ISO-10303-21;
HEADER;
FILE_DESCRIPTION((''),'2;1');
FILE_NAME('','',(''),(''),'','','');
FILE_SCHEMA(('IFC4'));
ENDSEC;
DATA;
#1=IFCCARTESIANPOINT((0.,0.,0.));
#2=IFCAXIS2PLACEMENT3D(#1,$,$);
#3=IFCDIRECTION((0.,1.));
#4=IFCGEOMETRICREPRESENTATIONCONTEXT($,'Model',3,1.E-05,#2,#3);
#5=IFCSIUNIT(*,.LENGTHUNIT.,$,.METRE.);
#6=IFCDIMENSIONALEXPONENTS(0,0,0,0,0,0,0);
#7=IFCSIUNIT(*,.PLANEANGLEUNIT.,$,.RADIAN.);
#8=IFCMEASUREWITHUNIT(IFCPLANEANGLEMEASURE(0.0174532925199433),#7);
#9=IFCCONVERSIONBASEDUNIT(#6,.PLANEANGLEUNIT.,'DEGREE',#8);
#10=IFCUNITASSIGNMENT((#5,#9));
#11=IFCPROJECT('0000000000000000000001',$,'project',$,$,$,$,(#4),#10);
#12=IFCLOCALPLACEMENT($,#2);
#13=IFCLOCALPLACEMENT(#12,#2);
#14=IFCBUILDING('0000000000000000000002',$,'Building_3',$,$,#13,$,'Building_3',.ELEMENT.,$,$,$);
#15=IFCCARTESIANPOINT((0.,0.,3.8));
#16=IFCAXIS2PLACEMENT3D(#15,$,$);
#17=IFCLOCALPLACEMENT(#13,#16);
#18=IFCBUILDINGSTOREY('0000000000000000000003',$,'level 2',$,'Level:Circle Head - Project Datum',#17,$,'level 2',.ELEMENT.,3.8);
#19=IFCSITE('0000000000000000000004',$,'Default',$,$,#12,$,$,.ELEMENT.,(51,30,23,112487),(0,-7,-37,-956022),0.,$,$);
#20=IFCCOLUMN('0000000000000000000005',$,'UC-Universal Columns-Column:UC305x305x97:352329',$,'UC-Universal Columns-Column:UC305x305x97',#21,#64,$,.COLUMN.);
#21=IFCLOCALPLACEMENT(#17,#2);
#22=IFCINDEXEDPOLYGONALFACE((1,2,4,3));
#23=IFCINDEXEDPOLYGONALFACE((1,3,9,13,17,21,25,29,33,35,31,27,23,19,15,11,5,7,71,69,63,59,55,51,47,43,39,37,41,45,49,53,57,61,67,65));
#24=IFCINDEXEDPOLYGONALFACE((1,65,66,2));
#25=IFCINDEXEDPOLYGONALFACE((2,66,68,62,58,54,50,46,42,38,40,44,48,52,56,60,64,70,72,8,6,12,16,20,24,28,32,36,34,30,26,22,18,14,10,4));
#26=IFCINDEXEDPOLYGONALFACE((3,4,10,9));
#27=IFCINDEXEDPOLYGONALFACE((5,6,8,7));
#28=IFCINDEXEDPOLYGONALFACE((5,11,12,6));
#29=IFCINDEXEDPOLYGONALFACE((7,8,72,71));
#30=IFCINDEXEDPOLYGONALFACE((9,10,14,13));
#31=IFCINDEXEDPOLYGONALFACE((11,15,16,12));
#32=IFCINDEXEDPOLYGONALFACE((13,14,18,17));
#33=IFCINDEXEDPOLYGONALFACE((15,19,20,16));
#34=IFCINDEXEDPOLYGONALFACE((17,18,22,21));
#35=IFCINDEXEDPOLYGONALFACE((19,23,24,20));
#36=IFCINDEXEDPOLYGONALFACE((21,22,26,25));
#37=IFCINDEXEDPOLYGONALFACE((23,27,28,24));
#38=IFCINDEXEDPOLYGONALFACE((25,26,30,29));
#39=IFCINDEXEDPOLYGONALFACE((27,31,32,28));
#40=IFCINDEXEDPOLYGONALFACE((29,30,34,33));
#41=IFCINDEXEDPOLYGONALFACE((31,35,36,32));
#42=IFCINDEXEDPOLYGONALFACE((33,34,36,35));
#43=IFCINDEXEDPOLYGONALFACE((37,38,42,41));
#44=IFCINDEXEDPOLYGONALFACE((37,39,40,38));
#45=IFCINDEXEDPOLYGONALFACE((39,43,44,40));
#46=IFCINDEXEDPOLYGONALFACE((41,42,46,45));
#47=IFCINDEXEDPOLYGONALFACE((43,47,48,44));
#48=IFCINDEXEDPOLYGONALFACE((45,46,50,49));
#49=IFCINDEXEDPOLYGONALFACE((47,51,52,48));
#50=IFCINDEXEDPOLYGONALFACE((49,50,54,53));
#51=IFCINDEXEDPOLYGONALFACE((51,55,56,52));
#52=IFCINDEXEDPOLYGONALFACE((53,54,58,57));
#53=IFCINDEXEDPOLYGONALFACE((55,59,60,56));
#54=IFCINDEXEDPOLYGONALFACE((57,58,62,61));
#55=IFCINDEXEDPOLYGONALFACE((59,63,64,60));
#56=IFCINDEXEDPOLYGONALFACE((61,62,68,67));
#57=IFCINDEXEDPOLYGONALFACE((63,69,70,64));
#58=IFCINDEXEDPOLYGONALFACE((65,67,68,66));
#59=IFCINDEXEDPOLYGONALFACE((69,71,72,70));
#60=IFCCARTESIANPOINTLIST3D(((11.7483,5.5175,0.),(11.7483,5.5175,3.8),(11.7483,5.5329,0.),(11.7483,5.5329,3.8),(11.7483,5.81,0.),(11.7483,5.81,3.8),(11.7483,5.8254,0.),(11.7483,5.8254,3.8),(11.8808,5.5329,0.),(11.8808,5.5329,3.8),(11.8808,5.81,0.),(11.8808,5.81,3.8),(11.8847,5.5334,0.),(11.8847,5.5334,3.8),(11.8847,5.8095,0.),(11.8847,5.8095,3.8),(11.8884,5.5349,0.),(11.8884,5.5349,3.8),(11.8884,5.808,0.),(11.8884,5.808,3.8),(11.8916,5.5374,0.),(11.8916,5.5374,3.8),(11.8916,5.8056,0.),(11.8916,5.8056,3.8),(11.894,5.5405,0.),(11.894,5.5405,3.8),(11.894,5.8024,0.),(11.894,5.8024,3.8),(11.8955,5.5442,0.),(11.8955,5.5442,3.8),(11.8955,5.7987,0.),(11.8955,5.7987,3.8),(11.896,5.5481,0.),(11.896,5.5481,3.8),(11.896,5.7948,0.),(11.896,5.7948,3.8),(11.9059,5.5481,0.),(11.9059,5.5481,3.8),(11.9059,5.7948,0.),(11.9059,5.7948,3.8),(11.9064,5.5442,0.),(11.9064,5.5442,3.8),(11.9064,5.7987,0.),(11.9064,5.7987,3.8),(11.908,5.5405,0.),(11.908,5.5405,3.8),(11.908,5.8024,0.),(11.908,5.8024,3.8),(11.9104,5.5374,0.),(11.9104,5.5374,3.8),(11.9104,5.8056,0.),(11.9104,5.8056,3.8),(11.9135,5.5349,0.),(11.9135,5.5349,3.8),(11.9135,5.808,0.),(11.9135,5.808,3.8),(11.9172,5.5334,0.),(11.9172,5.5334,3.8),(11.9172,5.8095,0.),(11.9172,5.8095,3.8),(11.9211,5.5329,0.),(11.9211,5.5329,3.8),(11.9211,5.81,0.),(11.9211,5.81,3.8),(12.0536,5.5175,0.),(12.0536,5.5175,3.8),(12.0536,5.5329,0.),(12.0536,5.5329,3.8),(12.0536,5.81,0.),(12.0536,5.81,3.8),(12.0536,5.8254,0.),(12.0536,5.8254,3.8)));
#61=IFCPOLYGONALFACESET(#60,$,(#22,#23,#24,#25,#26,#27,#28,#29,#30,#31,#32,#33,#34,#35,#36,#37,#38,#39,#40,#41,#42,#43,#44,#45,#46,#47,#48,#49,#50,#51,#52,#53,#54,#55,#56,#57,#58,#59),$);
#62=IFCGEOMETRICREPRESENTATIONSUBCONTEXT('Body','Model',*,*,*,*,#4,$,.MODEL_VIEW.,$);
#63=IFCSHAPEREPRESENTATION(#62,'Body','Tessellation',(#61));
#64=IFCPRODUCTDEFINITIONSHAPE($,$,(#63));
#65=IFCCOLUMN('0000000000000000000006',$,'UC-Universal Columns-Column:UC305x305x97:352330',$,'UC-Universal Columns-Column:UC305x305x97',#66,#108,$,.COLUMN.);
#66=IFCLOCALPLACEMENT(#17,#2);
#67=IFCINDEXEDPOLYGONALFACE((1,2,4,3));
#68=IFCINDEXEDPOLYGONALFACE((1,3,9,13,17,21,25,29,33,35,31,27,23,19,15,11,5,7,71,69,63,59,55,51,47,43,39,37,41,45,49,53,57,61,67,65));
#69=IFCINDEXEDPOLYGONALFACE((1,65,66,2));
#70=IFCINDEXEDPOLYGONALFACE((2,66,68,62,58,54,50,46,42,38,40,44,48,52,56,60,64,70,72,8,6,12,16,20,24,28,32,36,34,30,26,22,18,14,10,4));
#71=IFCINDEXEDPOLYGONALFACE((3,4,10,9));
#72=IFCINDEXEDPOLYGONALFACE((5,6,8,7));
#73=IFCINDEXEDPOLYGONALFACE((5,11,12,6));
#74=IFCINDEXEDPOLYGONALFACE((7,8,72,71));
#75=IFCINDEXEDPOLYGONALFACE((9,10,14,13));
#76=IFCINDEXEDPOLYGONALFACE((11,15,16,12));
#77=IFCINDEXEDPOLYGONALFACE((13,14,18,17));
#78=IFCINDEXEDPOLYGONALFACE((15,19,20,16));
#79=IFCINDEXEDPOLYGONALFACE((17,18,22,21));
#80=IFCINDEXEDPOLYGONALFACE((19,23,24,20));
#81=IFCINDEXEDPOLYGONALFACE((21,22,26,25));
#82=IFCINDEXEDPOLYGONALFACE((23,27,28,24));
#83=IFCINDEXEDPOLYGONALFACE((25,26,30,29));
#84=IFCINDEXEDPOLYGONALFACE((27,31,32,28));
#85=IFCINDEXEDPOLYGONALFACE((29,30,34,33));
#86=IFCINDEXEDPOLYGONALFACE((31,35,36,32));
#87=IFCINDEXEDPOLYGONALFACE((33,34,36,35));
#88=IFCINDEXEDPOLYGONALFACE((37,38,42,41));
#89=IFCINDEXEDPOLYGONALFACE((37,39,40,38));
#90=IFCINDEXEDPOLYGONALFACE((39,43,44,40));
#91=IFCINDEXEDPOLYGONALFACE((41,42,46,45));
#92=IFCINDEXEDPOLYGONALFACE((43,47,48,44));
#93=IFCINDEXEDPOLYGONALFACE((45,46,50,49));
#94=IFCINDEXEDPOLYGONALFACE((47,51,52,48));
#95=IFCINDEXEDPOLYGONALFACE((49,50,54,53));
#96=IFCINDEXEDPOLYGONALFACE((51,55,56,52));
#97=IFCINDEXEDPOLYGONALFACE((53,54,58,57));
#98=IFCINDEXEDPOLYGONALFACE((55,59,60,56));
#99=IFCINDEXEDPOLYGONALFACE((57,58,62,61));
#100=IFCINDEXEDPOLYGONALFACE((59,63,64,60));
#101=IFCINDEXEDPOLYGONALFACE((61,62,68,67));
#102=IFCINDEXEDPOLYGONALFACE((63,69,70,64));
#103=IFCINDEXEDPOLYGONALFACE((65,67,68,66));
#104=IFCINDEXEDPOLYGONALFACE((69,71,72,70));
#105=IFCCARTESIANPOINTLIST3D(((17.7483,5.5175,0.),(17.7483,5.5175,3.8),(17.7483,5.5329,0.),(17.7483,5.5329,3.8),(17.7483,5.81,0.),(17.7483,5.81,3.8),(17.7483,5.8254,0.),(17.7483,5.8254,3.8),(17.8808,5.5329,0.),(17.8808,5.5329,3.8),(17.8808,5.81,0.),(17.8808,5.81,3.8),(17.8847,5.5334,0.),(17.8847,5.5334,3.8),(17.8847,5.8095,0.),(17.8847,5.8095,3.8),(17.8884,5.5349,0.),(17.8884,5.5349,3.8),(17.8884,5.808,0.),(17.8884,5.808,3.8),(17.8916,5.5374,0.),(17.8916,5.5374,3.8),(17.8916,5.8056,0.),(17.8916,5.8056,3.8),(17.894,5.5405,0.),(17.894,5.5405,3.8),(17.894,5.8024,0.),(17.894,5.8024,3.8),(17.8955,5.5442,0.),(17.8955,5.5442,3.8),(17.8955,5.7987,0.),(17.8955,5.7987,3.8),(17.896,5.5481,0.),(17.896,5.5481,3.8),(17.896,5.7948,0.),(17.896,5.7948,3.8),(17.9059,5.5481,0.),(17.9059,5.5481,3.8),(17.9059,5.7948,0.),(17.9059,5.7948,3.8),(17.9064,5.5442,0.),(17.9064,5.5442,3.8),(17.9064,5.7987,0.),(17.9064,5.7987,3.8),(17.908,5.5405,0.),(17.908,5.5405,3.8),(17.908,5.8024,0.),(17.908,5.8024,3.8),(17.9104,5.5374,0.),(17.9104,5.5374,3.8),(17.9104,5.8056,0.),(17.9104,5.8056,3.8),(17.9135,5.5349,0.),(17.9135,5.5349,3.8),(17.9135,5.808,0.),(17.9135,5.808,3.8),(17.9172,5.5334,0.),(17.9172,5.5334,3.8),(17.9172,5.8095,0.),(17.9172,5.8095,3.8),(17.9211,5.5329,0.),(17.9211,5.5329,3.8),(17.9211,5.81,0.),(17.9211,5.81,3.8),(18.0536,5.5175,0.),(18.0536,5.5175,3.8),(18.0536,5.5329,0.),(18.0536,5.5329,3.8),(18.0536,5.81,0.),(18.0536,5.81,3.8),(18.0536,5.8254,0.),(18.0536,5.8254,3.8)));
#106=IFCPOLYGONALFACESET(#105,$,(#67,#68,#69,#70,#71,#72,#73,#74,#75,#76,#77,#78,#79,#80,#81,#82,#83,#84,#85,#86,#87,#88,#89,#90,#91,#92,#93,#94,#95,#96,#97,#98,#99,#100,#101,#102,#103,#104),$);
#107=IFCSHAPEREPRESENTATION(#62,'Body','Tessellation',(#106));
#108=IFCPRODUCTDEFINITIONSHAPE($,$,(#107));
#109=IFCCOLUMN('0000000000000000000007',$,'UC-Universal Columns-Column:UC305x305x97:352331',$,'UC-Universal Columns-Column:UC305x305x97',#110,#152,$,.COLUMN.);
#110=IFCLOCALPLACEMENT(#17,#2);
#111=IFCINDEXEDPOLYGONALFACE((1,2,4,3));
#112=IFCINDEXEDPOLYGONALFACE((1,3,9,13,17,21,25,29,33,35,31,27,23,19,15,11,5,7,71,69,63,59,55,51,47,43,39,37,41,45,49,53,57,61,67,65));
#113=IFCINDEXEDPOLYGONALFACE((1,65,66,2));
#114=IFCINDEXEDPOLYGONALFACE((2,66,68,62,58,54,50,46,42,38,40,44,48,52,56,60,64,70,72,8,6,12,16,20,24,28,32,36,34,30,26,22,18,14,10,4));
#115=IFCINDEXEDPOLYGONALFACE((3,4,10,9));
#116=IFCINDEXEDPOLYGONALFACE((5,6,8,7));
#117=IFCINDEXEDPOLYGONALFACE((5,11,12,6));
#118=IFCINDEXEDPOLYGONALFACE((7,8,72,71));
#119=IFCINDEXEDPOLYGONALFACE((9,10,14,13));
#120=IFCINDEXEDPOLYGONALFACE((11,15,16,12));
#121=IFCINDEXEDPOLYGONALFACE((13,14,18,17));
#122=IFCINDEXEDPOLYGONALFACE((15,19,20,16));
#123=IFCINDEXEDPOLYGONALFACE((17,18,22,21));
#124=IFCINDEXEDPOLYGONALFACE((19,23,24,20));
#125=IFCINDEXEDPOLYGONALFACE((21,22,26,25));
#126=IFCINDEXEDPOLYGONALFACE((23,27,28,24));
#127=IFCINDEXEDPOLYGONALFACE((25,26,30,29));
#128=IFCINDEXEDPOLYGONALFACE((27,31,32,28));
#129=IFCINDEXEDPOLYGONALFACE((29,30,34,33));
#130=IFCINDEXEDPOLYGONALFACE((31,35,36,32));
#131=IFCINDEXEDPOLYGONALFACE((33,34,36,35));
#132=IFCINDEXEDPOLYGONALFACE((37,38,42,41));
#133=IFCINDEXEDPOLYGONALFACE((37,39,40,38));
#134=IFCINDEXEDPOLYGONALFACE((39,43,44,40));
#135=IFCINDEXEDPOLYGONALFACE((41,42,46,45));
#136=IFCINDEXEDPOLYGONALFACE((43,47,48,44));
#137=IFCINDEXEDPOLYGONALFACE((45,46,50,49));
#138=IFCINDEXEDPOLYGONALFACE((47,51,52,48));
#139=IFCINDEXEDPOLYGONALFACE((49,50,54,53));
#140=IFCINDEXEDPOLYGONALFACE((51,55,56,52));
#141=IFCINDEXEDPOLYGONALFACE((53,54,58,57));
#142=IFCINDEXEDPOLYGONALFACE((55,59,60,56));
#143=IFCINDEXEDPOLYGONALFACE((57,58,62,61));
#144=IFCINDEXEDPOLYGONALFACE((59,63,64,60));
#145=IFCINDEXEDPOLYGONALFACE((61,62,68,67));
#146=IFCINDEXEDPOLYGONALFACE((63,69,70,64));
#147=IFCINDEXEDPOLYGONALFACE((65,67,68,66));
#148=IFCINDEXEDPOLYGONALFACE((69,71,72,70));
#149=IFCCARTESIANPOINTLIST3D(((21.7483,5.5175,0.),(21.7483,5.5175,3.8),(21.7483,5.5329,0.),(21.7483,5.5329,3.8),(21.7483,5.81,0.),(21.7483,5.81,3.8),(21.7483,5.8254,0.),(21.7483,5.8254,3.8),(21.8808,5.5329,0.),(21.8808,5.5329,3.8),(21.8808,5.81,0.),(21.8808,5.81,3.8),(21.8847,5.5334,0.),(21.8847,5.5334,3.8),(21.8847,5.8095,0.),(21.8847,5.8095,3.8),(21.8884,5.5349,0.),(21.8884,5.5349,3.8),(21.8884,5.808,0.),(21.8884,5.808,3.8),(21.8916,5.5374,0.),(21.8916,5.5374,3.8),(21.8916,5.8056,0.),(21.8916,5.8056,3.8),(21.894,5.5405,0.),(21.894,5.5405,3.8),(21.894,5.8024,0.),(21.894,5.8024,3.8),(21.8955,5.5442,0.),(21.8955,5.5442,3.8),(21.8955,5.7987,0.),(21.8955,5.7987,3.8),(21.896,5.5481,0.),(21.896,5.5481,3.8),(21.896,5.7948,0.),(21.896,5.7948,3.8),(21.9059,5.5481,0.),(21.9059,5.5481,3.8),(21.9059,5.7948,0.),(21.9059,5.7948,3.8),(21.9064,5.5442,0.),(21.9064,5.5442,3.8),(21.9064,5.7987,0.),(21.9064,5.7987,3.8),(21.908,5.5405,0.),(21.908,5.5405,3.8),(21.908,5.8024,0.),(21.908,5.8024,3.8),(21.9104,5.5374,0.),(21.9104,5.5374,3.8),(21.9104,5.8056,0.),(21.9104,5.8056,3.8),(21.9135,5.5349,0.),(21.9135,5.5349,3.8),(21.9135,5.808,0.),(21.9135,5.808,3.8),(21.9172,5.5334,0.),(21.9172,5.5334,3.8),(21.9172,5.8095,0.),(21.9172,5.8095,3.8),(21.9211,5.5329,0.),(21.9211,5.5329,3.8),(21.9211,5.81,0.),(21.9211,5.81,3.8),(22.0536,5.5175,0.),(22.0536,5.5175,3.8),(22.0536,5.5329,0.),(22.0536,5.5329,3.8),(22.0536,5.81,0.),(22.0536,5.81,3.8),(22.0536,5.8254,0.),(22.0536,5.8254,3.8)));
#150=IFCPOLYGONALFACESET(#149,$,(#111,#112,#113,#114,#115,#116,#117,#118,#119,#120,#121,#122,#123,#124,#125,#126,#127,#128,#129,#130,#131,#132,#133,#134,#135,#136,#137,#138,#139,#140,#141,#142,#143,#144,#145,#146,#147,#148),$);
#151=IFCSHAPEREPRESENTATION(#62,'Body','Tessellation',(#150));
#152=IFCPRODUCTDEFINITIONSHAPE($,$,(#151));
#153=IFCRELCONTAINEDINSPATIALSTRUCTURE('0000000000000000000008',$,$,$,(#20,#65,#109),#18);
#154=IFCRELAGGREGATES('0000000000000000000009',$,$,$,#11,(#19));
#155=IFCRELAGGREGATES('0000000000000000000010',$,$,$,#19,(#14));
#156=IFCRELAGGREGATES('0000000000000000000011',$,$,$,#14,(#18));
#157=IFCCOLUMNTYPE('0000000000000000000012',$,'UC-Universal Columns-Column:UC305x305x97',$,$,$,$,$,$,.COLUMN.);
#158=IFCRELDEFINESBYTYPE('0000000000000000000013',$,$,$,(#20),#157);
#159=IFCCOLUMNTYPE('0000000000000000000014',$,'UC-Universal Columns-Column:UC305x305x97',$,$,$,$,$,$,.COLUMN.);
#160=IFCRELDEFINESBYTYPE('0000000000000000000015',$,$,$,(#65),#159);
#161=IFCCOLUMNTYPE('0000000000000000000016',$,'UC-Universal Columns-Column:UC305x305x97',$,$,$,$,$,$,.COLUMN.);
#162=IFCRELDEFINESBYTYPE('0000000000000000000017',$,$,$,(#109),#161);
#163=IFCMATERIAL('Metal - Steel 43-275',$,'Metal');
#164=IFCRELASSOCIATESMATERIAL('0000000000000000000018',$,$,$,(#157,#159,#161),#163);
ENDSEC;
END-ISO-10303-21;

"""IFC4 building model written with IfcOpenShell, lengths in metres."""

from ifc_helpers import new_model, entity, si_unit, converted_unit, direction, frame, frame_2d, origin, place, context, subcontext, project, spatial, i_section, extrude, source, transform, mapped, material, material_profile, profile_set, type_object, type_shapes, element, save


model = new_model("IFC4")

# Units and contexts
model_context = context("Model", 3, precision=1e-05, world=origin(), true_north=direction((0.0, 1.0)))
body_context = subcontext(model_context, "Body", "Model", "MODEL_VIEW")
ifc_project = project(units=[si_unit("LENGTHUNIT", "METRE"), converted_unit("PLANEANGLEUNIT", "DEGREE", entity("IfcPlaneAngleMeasure", 0.0174532925199433), si_unit("PLANEANGLEUNIT", "RADIAN"), dimensions=[0, 0, 0, 0, 0, 0, 0])], contexts=[model_context])

# Site, building, storey
site_placement = place(None, origin())
site = spatial("IfcSite", under=ifc_project, at=site_placement, Name="Default", CompositionType="ELEMENT", RefLatitude=(51, 30, 23, 112487), RefLongitude=(0, -7, -37, -956022), RefElevation=0.0)
building_placement = place(site_placement, origin())
building = spatial("IfcBuilding", under=site, at=building_placement, Name="Building_3", LongName="Building_3", CompositionType="ELEMENT")
storey_placement = place(building_placement, frame((0.0, 0.0, 3.8)))
storey = spatial("IfcBuildingStorey", under=building, at=storey_placement, Name="level 2", ObjectType="Level:Circle Head - Project Datum", LongName="level 2", CompositionType="ELEMENT", Elevation=3.8)

# Columns
ifc_material_1 = material(Name="Metal - Steel 43-275", Category="Metal")
ifc_material_profile_1 = material_profile(ifc_material_1, i_section(OverallWidth=0.3053, OverallDepth=0.3079, WebThickness=0.0099, FlangeThickness=0.0154, FilletRadius=0.0152, at=frame_2d((0.0, 0.0), x_axis=(1.0, 0.0))), Name="UC305x305x97")
ifc_profile_set_1 = profile_set([ifc_material_profile_1], Name="UC305x305x97")
column_type_1 = type_object("IfcColumnType", Name="UC-Universal Columns-Column:UC305x305x97", PredefinedType="COLUMN", material=ifc_profile_set_1)
shared_shape_1 = source(origin(), body_context, "Body", "SweptSolid", [
    extrude(i_section(OverallWidth=0.3053, OverallDepth=0.3079, WebThickness=0.0099, FlangeThickness=0.0154, FilletRadius=0.0152, at=frame_2d((0.0, 0.0), x_axis=(1.0, 0.0))), frame((11.901, 5.6715, 3.8), z_axis=(0.0, 0.0, 1.0), x_axis=(-1.0, 0.0, 0.0)), (0.0, 0.0, 1.0), 3.8),
])
type_shapes(column_type_1, [shared_shape_1])
column_1_placement = place(storey_placement, frame((0.0, 0.0, -3.8)))
element("IfcColumn", 1, at=column_1_placement, inside=storey, type_object=column_type_1, Name="UC-Universal Columns-Column:UC305x305x97:352329", ObjectType="UC-Universal Columns-Column:UC305x305x97", PredefinedType="COLUMN", context=body_context, shape_type="MappedRepresentation", body=[
    mapped(shared_shape_1, transform((0.0, 0.0, 0.0), scale=1.0)),
])
column_type_2 = type_object("IfcColumnType", Name="UC-Universal Columns-Column:UC305x305x97", PredefinedType="COLUMN", material=ifc_profile_set_1)
shared_shape_2 = source(origin(), body_context, "Body", "SweptSolid", [
    extrude(i_section(OverallWidth=0.3053, OverallDepth=0.3079, WebThickness=0.0099, FlangeThickness=0.0154, FilletRadius=0.0152, at=frame_2d((0.0, 0.0), x_axis=(1.0, 0.0))), frame((17.901, 5.6715, 3.8), z_axis=(0.0, 0.0, 1.0), x_axis=(-1.0, 0.0, 0.0)), (0.0, 0.0, 1.0), 3.8),
])
type_shapes(column_type_2, [shared_shape_2])
column_2_placement = place(storey_placement, frame((0.0, 0.0, -3.8)))
element("IfcColumn", 2, at=column_2_placement, inside=storey, type_object=column_type_2, Name="UC-Universal Columns-Column:UC305x305x97:352330", ObjectType="UC-Universal Columns-Column:UC305x305x97", PredefinedType="COLUMN", context=body_context, shape_type="MappedRepresentation", body=[
    mapped(shared_shape_2, transform((0.0, 0.0, 0.0), scale=1.0)),
])
column_type_3 = type_object("IfcColumnType", Name="UC-Universal Columns-Column:UC305x305x97", PredefinedType="COLUMN", material=ifc_profile_set_1)
shared_shape_3 = source(origin(), body_context, "Body", "SweptSolid", [
    extrude(i_section(OverallWidth=0.3053, OverallDepth=0.3079, WebThickness=0.0099, FlangeThickness=0.0154, FilletRadius=0.0152, at=frame_2d((0.0, 0.0), x_axis=(1.0, 0.0))), frame((21.901, 5.6715, 3.8), z_axis=(0.0, 0.0, 1.0), x_axis=(-1.0, 0.0, 0.0)), (0.0, 0.0, 1.0), 3.8),
])
type_shapes(column_type_3, [shared_shape_3])
column_3_placement = place(storey_placement, frame((0.0, 0.0, -3.8)))
element("IfcColumn", 3, at=column_3_placement, inside=storey, type_object=column_type_3, Name="UC-Universal Columns-Column:UC305x305x97:352331", ObjectType="UC-Universal Columns-Column:UC305x305x97", PredefinedType="COLUMN", context=body_context, shape_type="MappedRepresentation", body=[
    mapped(shared_shape_3, transform((0.0, 0.0, 0.0), scale=1.0)),
])

save(model, "model.ifc")
